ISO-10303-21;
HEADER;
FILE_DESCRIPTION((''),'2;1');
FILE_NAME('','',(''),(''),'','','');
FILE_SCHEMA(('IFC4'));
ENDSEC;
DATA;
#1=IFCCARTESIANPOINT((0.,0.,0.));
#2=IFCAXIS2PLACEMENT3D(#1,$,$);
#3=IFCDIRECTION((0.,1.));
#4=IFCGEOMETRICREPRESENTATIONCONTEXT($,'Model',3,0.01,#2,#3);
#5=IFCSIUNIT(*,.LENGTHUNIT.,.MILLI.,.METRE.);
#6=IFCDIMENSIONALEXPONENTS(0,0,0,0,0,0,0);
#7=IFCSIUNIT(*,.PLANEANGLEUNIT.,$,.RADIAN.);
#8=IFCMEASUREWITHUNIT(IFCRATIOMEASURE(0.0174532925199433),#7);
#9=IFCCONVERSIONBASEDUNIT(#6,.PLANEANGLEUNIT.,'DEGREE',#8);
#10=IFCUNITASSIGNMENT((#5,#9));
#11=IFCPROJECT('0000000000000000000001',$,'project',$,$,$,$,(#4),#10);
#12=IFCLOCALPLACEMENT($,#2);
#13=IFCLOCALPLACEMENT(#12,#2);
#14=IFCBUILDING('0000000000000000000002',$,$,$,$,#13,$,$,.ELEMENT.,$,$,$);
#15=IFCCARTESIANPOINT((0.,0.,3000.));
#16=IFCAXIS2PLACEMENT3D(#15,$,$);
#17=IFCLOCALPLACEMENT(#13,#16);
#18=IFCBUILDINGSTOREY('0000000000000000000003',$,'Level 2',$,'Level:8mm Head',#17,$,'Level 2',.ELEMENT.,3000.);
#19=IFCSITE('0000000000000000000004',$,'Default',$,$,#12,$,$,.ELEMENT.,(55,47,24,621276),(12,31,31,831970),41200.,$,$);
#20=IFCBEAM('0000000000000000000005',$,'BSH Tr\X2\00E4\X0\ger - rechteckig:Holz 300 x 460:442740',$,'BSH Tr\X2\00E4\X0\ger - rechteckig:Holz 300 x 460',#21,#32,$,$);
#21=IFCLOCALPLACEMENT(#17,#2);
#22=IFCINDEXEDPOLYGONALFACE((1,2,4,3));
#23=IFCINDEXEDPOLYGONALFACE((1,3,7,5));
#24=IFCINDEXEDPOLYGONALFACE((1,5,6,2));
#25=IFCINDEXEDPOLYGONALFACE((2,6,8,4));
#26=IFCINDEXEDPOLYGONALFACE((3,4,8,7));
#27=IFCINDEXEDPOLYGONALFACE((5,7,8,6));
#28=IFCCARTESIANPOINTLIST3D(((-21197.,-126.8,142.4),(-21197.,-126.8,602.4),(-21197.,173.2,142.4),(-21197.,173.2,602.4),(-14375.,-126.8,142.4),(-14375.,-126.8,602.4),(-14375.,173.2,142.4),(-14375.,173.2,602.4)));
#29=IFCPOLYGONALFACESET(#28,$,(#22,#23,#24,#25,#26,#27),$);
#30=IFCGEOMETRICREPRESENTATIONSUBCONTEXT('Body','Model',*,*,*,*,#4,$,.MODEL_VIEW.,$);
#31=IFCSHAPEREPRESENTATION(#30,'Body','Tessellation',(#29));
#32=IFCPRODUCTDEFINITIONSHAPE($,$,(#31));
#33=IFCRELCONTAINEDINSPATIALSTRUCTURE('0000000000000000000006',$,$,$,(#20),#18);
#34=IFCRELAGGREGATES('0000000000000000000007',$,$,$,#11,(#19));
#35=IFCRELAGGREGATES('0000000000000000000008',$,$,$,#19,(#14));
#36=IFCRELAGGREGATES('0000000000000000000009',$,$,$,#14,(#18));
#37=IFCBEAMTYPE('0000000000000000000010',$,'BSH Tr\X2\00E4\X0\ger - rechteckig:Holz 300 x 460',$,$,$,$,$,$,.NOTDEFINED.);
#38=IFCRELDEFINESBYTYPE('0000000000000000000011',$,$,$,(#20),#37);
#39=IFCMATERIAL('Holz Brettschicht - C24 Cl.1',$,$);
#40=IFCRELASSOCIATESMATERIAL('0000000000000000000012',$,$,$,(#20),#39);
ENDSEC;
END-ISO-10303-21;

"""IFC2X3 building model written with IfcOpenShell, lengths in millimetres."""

from ifc_helpers import new_model, entity, si_unit, converted_unit, direction, frame, frame_2d, origin, place, context, subcontext, project, spatial, rectangle, extrude, material, type_object, element, save


model = new_model("IFC2X3")

# Units and contexts
model_context = context("Model", 3, precision=0.01, world=origin(), true_north=direction((0.0, 1.0)))
body_context = subcontext(model_context, "Body", "Model", "MODEL_VIEW")
ifc_project = project(units=[si_unit("LENGTHUNIT", "METRE", prefix="MILLI"), converted_unit("PLANEANGLEUNIT", "DEGREE", entity("IfcRatioMeasure", 0.0174532925199433), si_unit("PLANEANGLEUNIT", "RADIAN"), dimensions=[0, 0, 0, 0, 0, 0, 0])], contexts=[model_context])

# Site, building, storey
site_placement = place(None, origin())
site = spatial("IfcSite", under=ifc_project, at=site_placement, Name="Default", CompositionType="ELEMENT", RefLatitude=(55, 47, 24, 621276), RefLongitude=(12, 31, 31, 831970), RefElevation=41200.0)
building_placement = place(site_placement, origin())
building = spatial("IfcBuilding", under=site, at=building_placement, CompositionType="ELEMENT")
storey_placement = place(building_placement, frame((0.0, 0.0, 3000.0)))
storey = spatial("IfcBuildingStorey", under=building, at=storey_placement, Name="Level 2", ObjectType="Level:8mm Head", LongName="Level 2", CompositionType="ELEMENT", Elevation=3000.0)

# Beam
ifc_material_1 = material(Name="Holz Brettschicht - C24 Cl.1")
beam_type_1 = type_object("IfcBeamType", Name="BSH Träger - rechteckig:Holz 300 x 460", PredefinedType="NOTDEFINED")
beam_1_placement = place(storey_placement, frame((-14041.8, 23.2, 602.4), z_axis=(0.0, 0.0, 1.0), x_axis=(-1.0, 0.0, 0.0)))
element("IfcBeam", 1, at=beam_1_placement, inside=storey, type_object=beam_type_1, material=ifc_material_1, Name="BSH Träger - rechteckig:Holz 300 x 460:442740", ObjectType="BSH Träger - rechteckig:Holz 300 x 460", context=body_context, shape_type="SweptSolid", body=[
    extrude(rectangle(XDim=460.0, YDim=300.0, at=frame_2d((0.0, 0.0), x_axis=(1.0, 0.0))), frame((333.2, 0.0, -230.0), z_axis=(1.0, 0.0, 0.0), x_axis=(0.0, 0.0, -1.0)), (0.0, 0.0, 1.0), 6822.0),
])

save(model, "model.ifc")
